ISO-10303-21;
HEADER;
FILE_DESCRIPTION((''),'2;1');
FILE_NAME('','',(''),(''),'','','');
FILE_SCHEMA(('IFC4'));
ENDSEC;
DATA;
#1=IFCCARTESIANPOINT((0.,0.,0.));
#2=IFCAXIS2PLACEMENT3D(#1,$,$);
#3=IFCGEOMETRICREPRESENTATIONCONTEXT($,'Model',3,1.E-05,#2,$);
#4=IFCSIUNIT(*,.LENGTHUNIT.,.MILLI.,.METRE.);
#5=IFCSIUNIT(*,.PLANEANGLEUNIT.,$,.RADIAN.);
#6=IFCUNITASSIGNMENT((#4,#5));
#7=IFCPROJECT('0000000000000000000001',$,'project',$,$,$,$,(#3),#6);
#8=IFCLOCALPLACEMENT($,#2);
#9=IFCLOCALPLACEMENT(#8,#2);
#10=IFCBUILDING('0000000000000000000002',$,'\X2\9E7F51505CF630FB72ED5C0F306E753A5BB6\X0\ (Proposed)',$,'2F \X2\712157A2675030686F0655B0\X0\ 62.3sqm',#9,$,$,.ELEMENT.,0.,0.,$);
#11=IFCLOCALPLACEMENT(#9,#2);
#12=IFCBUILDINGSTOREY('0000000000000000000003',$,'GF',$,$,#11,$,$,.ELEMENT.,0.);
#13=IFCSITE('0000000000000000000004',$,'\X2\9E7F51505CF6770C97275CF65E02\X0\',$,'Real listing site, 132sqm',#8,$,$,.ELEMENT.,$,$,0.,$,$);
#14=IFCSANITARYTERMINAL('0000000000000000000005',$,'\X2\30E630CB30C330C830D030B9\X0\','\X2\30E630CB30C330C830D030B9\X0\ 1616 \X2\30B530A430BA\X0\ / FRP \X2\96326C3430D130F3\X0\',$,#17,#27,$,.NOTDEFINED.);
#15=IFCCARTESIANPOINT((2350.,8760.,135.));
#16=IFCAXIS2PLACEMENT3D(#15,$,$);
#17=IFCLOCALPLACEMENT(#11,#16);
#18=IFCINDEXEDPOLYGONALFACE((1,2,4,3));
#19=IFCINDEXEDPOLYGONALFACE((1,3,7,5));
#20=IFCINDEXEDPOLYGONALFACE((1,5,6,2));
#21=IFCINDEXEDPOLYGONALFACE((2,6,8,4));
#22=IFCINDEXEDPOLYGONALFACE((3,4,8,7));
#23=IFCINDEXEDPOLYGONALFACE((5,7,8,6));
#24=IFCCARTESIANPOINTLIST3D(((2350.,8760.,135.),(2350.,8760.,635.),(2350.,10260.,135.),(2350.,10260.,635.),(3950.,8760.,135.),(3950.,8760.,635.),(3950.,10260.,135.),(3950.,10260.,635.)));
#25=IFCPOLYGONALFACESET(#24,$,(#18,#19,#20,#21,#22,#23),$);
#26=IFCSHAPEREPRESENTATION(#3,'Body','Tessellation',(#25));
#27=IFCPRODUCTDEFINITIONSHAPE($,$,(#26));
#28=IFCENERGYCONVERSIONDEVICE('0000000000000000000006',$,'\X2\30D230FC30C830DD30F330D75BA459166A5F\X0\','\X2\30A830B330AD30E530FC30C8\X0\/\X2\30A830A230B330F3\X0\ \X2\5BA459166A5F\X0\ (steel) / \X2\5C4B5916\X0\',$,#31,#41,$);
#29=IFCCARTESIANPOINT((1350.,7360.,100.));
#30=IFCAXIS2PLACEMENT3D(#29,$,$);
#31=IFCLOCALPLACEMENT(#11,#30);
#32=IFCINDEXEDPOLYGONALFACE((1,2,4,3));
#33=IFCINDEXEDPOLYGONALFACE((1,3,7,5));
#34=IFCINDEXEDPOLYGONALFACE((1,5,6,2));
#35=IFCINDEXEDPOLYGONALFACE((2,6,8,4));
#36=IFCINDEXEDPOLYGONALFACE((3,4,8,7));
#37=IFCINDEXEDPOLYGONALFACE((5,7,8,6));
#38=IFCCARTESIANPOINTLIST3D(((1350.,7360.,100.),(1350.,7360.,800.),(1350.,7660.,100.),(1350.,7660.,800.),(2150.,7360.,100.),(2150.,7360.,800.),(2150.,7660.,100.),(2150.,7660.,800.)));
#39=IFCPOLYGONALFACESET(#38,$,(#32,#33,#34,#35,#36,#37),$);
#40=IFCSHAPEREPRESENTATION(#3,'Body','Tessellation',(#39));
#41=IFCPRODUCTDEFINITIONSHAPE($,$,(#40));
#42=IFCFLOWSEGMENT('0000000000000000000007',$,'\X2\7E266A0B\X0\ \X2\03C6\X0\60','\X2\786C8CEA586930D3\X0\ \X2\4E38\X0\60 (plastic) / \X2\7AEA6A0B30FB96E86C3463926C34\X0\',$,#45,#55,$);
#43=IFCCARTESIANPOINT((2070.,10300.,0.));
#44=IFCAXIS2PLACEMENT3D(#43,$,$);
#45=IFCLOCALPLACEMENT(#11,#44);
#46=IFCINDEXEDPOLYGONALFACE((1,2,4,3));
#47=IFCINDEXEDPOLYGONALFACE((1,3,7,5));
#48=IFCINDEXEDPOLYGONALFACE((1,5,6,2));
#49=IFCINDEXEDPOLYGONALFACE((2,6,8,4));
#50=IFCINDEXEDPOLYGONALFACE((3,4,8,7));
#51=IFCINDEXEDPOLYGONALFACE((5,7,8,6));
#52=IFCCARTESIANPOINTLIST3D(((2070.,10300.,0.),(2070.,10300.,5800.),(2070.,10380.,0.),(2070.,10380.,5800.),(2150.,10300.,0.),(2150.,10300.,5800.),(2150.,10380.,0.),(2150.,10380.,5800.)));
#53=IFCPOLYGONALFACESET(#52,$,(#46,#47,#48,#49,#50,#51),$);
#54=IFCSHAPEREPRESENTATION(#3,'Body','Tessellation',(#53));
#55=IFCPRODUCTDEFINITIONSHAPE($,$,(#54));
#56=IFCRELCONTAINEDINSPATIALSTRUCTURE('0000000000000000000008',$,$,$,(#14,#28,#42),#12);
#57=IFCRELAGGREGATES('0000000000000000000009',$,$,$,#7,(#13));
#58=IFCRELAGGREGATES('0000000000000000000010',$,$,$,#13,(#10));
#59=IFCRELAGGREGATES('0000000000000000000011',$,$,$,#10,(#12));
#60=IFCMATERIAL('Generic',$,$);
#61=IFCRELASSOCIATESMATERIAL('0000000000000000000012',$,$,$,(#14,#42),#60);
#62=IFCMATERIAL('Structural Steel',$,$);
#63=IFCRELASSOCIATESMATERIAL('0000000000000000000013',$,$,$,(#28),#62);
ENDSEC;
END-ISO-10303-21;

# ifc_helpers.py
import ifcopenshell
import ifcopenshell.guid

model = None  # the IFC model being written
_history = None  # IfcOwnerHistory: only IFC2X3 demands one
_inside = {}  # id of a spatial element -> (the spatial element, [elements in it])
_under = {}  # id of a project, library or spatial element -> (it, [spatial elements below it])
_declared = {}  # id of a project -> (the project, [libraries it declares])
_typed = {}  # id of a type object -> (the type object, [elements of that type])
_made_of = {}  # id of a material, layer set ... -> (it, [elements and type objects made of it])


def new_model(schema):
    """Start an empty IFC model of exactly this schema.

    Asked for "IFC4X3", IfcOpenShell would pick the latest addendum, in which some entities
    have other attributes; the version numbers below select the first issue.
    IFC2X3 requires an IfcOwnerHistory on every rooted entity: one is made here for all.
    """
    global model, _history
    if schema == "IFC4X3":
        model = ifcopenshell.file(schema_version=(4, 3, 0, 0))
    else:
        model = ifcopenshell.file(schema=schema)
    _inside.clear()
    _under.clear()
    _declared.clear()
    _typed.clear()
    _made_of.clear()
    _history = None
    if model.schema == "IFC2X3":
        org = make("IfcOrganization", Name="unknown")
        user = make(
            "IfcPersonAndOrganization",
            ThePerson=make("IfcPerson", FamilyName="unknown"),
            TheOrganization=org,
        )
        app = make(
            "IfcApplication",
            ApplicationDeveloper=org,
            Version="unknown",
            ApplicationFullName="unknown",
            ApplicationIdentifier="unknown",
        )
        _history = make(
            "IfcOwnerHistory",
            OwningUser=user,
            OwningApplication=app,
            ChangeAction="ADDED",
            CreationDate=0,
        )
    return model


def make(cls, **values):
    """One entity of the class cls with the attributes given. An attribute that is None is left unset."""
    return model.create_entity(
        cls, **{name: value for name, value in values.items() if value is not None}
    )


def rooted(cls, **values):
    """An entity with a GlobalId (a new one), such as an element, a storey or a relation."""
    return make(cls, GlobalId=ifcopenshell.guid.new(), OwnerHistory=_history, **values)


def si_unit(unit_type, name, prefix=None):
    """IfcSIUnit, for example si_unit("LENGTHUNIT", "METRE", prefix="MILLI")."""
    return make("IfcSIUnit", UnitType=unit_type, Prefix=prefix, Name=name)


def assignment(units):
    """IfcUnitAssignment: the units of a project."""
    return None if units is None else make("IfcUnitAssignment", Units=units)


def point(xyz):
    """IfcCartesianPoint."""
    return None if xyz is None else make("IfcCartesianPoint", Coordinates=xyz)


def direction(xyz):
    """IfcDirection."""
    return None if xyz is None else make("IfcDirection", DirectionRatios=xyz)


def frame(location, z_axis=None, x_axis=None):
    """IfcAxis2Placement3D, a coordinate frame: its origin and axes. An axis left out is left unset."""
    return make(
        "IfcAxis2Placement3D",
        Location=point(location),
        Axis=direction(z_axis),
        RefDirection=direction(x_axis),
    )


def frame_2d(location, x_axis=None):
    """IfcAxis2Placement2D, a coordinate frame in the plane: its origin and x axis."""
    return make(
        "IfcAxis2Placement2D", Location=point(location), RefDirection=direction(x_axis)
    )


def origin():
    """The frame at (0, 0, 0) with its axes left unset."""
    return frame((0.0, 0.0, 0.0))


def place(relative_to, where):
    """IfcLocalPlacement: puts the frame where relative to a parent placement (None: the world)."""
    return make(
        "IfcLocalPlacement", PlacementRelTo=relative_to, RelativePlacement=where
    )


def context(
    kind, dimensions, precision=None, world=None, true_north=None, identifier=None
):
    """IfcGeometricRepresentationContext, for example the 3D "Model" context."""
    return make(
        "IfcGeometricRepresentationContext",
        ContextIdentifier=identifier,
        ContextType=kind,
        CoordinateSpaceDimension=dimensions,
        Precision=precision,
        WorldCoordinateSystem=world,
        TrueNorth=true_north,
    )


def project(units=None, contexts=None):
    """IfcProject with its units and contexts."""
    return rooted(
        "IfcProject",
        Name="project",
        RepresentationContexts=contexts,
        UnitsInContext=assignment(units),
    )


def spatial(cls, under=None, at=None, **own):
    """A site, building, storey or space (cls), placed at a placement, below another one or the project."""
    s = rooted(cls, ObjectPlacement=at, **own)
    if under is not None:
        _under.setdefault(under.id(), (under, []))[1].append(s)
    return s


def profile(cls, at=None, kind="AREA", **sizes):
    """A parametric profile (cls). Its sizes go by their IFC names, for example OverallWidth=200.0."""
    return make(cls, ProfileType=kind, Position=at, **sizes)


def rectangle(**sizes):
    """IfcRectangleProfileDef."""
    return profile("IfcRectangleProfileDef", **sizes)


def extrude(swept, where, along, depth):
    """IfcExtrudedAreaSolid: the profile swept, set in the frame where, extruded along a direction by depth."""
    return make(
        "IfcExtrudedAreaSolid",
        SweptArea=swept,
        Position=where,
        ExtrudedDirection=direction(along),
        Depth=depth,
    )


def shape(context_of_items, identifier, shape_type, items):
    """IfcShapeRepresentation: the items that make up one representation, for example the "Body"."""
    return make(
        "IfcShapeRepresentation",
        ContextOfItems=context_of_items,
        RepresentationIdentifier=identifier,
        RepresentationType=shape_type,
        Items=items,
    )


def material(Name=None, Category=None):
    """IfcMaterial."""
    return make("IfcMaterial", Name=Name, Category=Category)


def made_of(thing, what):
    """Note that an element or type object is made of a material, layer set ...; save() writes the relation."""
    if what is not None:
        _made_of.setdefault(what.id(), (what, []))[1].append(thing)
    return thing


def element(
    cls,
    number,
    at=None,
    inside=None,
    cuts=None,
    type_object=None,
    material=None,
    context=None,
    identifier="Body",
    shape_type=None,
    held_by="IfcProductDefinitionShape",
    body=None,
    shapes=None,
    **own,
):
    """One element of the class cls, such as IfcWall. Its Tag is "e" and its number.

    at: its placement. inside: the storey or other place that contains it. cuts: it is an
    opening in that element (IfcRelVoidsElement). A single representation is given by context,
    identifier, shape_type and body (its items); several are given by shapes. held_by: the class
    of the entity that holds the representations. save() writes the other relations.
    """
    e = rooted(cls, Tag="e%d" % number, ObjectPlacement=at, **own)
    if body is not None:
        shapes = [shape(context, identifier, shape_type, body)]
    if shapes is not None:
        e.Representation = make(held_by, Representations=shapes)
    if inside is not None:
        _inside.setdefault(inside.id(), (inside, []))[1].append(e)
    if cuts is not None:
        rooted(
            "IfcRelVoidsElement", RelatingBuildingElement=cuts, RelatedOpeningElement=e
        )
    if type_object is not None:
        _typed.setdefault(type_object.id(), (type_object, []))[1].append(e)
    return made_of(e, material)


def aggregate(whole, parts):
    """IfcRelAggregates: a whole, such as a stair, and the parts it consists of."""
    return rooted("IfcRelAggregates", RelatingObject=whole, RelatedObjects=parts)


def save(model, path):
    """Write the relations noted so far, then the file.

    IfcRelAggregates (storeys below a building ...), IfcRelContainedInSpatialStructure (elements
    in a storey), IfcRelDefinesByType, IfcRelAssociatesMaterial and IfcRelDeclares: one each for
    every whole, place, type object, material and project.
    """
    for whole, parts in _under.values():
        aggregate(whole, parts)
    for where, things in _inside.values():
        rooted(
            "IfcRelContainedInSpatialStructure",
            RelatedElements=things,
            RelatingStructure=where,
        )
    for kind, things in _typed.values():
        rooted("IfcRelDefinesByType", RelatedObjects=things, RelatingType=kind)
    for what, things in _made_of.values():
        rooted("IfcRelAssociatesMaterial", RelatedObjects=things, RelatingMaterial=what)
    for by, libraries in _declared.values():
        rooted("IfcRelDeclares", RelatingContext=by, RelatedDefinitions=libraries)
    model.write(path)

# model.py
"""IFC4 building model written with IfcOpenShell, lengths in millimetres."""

from ifc_helpers import new_model, si_unit, frame, frame_2d, origin, place, context, project, spatial, rectangle, extrude, material, element, save


model = new_model("IFC4")

# Units and contexts
model_context = context("Model", 3, precision=1e-05, world=origin())
ifc_project = project(units=[si_unit("LENGTHUNIT", "METRE", prefix="MILLI"), si_unit("PLANEANGLEUNIT", "RADIAN")], contexts=[model_context])

# Site, building, storey
site_placement = place(None, origin())
site = spatial("IfcSite", under=ifc_project, at=site_placement, Name="鹿児島県霧島市", ObjectType="Real listing site, 132sqm", CompositionType="ELEMENT", RefElevation=0.0)
building_placement = place(site_placement, origin())
building = spatial("IfcBuilding", under=site, at=building_placement, Name="鹿児島・狭小の町家 (Proposed)", ObjectType="2F 無垢材と漆喰 62.3sqm", CompositionType="ELEMENT", ElevationOfRefHeight=0.0, ElevationOfTerrain=0.0)
storey_placement = place(building_placement, origin())
storey = spatial("IfcBuildingStorey", under=building, at=storey_placement, Name="GF", CompositionType="ELEMENT", Elevation=0.0)

# Shared definitions
ifc_material_1 = material(Name="Generic")

# Sanitary terminal
sanitary_terminal_placement = place(storey_placement, frame((2350.0, 8760.0, 135.0)))
element("IfcSanitaryTerminal", 1, at=sanitary_terminal_placement, inside=storey, material=ifc_material_1, Name="ユニットバス", Description="ユニットバス 1616 サイズ / FRP 防水パン", PredefinedType="NOTDEFINED", context=model_context, shape_type="SweptSolid", body=[
    extrude(rectangle(XDim=1600.0, YDim=1500.0, at=frame_2d((800.0, 750.0))), frame((2350.0, 8760.0, 135.0)), (0.0, 0.0, 1.0), 500.0),
])

# Energy conversion device
ifc_material_2 = material(Name="Structural Steel")
energy_conversion_device_placement = place(storey_placement, frame((1350.0, 7360.0, 100.0)))
element("IfcEnergyConversionDevice", 2, at=energy_conversion_device_placement, inside=storey, material=ifc_material_2, Name="ヒートポンプ室外機", Description="エコキュート/エアコン 室外機 (steel) / 屋外", context=model_context, shape_type="SweptSolid", body=[
    extrude(rectangle(XDim=800.0, YDim=300.0, at=frame_2d((400.0, 150.0))), frame((1350.0, 7360.0, 100.0)), (0.0, 0.0, 1.0), 700.0),
])

# Flow segment
flow_segment_placement = place(storey_placement, frame((2070.0, 10300.0, 0.0)))
element("IfcFlowSegment", 3, at=flow_segment_placement, inside=storey, material=ifc_material_1, Name="縦樋 φ60", Description="硬質塩ビ 丸60 (plastic) / 竪樋・雨水排水", context=model_context, shape_type="SweptSolid", body=[
    extrude(rectangle(XDim=80.0, YDim=80.0, at=frame_2d((40.0, 40.0))), frame((2070.0, 10300.0, 0.0)), (0.0, 0.0, 1.0), 5800.0),
])

save(model, "model.ifc")
